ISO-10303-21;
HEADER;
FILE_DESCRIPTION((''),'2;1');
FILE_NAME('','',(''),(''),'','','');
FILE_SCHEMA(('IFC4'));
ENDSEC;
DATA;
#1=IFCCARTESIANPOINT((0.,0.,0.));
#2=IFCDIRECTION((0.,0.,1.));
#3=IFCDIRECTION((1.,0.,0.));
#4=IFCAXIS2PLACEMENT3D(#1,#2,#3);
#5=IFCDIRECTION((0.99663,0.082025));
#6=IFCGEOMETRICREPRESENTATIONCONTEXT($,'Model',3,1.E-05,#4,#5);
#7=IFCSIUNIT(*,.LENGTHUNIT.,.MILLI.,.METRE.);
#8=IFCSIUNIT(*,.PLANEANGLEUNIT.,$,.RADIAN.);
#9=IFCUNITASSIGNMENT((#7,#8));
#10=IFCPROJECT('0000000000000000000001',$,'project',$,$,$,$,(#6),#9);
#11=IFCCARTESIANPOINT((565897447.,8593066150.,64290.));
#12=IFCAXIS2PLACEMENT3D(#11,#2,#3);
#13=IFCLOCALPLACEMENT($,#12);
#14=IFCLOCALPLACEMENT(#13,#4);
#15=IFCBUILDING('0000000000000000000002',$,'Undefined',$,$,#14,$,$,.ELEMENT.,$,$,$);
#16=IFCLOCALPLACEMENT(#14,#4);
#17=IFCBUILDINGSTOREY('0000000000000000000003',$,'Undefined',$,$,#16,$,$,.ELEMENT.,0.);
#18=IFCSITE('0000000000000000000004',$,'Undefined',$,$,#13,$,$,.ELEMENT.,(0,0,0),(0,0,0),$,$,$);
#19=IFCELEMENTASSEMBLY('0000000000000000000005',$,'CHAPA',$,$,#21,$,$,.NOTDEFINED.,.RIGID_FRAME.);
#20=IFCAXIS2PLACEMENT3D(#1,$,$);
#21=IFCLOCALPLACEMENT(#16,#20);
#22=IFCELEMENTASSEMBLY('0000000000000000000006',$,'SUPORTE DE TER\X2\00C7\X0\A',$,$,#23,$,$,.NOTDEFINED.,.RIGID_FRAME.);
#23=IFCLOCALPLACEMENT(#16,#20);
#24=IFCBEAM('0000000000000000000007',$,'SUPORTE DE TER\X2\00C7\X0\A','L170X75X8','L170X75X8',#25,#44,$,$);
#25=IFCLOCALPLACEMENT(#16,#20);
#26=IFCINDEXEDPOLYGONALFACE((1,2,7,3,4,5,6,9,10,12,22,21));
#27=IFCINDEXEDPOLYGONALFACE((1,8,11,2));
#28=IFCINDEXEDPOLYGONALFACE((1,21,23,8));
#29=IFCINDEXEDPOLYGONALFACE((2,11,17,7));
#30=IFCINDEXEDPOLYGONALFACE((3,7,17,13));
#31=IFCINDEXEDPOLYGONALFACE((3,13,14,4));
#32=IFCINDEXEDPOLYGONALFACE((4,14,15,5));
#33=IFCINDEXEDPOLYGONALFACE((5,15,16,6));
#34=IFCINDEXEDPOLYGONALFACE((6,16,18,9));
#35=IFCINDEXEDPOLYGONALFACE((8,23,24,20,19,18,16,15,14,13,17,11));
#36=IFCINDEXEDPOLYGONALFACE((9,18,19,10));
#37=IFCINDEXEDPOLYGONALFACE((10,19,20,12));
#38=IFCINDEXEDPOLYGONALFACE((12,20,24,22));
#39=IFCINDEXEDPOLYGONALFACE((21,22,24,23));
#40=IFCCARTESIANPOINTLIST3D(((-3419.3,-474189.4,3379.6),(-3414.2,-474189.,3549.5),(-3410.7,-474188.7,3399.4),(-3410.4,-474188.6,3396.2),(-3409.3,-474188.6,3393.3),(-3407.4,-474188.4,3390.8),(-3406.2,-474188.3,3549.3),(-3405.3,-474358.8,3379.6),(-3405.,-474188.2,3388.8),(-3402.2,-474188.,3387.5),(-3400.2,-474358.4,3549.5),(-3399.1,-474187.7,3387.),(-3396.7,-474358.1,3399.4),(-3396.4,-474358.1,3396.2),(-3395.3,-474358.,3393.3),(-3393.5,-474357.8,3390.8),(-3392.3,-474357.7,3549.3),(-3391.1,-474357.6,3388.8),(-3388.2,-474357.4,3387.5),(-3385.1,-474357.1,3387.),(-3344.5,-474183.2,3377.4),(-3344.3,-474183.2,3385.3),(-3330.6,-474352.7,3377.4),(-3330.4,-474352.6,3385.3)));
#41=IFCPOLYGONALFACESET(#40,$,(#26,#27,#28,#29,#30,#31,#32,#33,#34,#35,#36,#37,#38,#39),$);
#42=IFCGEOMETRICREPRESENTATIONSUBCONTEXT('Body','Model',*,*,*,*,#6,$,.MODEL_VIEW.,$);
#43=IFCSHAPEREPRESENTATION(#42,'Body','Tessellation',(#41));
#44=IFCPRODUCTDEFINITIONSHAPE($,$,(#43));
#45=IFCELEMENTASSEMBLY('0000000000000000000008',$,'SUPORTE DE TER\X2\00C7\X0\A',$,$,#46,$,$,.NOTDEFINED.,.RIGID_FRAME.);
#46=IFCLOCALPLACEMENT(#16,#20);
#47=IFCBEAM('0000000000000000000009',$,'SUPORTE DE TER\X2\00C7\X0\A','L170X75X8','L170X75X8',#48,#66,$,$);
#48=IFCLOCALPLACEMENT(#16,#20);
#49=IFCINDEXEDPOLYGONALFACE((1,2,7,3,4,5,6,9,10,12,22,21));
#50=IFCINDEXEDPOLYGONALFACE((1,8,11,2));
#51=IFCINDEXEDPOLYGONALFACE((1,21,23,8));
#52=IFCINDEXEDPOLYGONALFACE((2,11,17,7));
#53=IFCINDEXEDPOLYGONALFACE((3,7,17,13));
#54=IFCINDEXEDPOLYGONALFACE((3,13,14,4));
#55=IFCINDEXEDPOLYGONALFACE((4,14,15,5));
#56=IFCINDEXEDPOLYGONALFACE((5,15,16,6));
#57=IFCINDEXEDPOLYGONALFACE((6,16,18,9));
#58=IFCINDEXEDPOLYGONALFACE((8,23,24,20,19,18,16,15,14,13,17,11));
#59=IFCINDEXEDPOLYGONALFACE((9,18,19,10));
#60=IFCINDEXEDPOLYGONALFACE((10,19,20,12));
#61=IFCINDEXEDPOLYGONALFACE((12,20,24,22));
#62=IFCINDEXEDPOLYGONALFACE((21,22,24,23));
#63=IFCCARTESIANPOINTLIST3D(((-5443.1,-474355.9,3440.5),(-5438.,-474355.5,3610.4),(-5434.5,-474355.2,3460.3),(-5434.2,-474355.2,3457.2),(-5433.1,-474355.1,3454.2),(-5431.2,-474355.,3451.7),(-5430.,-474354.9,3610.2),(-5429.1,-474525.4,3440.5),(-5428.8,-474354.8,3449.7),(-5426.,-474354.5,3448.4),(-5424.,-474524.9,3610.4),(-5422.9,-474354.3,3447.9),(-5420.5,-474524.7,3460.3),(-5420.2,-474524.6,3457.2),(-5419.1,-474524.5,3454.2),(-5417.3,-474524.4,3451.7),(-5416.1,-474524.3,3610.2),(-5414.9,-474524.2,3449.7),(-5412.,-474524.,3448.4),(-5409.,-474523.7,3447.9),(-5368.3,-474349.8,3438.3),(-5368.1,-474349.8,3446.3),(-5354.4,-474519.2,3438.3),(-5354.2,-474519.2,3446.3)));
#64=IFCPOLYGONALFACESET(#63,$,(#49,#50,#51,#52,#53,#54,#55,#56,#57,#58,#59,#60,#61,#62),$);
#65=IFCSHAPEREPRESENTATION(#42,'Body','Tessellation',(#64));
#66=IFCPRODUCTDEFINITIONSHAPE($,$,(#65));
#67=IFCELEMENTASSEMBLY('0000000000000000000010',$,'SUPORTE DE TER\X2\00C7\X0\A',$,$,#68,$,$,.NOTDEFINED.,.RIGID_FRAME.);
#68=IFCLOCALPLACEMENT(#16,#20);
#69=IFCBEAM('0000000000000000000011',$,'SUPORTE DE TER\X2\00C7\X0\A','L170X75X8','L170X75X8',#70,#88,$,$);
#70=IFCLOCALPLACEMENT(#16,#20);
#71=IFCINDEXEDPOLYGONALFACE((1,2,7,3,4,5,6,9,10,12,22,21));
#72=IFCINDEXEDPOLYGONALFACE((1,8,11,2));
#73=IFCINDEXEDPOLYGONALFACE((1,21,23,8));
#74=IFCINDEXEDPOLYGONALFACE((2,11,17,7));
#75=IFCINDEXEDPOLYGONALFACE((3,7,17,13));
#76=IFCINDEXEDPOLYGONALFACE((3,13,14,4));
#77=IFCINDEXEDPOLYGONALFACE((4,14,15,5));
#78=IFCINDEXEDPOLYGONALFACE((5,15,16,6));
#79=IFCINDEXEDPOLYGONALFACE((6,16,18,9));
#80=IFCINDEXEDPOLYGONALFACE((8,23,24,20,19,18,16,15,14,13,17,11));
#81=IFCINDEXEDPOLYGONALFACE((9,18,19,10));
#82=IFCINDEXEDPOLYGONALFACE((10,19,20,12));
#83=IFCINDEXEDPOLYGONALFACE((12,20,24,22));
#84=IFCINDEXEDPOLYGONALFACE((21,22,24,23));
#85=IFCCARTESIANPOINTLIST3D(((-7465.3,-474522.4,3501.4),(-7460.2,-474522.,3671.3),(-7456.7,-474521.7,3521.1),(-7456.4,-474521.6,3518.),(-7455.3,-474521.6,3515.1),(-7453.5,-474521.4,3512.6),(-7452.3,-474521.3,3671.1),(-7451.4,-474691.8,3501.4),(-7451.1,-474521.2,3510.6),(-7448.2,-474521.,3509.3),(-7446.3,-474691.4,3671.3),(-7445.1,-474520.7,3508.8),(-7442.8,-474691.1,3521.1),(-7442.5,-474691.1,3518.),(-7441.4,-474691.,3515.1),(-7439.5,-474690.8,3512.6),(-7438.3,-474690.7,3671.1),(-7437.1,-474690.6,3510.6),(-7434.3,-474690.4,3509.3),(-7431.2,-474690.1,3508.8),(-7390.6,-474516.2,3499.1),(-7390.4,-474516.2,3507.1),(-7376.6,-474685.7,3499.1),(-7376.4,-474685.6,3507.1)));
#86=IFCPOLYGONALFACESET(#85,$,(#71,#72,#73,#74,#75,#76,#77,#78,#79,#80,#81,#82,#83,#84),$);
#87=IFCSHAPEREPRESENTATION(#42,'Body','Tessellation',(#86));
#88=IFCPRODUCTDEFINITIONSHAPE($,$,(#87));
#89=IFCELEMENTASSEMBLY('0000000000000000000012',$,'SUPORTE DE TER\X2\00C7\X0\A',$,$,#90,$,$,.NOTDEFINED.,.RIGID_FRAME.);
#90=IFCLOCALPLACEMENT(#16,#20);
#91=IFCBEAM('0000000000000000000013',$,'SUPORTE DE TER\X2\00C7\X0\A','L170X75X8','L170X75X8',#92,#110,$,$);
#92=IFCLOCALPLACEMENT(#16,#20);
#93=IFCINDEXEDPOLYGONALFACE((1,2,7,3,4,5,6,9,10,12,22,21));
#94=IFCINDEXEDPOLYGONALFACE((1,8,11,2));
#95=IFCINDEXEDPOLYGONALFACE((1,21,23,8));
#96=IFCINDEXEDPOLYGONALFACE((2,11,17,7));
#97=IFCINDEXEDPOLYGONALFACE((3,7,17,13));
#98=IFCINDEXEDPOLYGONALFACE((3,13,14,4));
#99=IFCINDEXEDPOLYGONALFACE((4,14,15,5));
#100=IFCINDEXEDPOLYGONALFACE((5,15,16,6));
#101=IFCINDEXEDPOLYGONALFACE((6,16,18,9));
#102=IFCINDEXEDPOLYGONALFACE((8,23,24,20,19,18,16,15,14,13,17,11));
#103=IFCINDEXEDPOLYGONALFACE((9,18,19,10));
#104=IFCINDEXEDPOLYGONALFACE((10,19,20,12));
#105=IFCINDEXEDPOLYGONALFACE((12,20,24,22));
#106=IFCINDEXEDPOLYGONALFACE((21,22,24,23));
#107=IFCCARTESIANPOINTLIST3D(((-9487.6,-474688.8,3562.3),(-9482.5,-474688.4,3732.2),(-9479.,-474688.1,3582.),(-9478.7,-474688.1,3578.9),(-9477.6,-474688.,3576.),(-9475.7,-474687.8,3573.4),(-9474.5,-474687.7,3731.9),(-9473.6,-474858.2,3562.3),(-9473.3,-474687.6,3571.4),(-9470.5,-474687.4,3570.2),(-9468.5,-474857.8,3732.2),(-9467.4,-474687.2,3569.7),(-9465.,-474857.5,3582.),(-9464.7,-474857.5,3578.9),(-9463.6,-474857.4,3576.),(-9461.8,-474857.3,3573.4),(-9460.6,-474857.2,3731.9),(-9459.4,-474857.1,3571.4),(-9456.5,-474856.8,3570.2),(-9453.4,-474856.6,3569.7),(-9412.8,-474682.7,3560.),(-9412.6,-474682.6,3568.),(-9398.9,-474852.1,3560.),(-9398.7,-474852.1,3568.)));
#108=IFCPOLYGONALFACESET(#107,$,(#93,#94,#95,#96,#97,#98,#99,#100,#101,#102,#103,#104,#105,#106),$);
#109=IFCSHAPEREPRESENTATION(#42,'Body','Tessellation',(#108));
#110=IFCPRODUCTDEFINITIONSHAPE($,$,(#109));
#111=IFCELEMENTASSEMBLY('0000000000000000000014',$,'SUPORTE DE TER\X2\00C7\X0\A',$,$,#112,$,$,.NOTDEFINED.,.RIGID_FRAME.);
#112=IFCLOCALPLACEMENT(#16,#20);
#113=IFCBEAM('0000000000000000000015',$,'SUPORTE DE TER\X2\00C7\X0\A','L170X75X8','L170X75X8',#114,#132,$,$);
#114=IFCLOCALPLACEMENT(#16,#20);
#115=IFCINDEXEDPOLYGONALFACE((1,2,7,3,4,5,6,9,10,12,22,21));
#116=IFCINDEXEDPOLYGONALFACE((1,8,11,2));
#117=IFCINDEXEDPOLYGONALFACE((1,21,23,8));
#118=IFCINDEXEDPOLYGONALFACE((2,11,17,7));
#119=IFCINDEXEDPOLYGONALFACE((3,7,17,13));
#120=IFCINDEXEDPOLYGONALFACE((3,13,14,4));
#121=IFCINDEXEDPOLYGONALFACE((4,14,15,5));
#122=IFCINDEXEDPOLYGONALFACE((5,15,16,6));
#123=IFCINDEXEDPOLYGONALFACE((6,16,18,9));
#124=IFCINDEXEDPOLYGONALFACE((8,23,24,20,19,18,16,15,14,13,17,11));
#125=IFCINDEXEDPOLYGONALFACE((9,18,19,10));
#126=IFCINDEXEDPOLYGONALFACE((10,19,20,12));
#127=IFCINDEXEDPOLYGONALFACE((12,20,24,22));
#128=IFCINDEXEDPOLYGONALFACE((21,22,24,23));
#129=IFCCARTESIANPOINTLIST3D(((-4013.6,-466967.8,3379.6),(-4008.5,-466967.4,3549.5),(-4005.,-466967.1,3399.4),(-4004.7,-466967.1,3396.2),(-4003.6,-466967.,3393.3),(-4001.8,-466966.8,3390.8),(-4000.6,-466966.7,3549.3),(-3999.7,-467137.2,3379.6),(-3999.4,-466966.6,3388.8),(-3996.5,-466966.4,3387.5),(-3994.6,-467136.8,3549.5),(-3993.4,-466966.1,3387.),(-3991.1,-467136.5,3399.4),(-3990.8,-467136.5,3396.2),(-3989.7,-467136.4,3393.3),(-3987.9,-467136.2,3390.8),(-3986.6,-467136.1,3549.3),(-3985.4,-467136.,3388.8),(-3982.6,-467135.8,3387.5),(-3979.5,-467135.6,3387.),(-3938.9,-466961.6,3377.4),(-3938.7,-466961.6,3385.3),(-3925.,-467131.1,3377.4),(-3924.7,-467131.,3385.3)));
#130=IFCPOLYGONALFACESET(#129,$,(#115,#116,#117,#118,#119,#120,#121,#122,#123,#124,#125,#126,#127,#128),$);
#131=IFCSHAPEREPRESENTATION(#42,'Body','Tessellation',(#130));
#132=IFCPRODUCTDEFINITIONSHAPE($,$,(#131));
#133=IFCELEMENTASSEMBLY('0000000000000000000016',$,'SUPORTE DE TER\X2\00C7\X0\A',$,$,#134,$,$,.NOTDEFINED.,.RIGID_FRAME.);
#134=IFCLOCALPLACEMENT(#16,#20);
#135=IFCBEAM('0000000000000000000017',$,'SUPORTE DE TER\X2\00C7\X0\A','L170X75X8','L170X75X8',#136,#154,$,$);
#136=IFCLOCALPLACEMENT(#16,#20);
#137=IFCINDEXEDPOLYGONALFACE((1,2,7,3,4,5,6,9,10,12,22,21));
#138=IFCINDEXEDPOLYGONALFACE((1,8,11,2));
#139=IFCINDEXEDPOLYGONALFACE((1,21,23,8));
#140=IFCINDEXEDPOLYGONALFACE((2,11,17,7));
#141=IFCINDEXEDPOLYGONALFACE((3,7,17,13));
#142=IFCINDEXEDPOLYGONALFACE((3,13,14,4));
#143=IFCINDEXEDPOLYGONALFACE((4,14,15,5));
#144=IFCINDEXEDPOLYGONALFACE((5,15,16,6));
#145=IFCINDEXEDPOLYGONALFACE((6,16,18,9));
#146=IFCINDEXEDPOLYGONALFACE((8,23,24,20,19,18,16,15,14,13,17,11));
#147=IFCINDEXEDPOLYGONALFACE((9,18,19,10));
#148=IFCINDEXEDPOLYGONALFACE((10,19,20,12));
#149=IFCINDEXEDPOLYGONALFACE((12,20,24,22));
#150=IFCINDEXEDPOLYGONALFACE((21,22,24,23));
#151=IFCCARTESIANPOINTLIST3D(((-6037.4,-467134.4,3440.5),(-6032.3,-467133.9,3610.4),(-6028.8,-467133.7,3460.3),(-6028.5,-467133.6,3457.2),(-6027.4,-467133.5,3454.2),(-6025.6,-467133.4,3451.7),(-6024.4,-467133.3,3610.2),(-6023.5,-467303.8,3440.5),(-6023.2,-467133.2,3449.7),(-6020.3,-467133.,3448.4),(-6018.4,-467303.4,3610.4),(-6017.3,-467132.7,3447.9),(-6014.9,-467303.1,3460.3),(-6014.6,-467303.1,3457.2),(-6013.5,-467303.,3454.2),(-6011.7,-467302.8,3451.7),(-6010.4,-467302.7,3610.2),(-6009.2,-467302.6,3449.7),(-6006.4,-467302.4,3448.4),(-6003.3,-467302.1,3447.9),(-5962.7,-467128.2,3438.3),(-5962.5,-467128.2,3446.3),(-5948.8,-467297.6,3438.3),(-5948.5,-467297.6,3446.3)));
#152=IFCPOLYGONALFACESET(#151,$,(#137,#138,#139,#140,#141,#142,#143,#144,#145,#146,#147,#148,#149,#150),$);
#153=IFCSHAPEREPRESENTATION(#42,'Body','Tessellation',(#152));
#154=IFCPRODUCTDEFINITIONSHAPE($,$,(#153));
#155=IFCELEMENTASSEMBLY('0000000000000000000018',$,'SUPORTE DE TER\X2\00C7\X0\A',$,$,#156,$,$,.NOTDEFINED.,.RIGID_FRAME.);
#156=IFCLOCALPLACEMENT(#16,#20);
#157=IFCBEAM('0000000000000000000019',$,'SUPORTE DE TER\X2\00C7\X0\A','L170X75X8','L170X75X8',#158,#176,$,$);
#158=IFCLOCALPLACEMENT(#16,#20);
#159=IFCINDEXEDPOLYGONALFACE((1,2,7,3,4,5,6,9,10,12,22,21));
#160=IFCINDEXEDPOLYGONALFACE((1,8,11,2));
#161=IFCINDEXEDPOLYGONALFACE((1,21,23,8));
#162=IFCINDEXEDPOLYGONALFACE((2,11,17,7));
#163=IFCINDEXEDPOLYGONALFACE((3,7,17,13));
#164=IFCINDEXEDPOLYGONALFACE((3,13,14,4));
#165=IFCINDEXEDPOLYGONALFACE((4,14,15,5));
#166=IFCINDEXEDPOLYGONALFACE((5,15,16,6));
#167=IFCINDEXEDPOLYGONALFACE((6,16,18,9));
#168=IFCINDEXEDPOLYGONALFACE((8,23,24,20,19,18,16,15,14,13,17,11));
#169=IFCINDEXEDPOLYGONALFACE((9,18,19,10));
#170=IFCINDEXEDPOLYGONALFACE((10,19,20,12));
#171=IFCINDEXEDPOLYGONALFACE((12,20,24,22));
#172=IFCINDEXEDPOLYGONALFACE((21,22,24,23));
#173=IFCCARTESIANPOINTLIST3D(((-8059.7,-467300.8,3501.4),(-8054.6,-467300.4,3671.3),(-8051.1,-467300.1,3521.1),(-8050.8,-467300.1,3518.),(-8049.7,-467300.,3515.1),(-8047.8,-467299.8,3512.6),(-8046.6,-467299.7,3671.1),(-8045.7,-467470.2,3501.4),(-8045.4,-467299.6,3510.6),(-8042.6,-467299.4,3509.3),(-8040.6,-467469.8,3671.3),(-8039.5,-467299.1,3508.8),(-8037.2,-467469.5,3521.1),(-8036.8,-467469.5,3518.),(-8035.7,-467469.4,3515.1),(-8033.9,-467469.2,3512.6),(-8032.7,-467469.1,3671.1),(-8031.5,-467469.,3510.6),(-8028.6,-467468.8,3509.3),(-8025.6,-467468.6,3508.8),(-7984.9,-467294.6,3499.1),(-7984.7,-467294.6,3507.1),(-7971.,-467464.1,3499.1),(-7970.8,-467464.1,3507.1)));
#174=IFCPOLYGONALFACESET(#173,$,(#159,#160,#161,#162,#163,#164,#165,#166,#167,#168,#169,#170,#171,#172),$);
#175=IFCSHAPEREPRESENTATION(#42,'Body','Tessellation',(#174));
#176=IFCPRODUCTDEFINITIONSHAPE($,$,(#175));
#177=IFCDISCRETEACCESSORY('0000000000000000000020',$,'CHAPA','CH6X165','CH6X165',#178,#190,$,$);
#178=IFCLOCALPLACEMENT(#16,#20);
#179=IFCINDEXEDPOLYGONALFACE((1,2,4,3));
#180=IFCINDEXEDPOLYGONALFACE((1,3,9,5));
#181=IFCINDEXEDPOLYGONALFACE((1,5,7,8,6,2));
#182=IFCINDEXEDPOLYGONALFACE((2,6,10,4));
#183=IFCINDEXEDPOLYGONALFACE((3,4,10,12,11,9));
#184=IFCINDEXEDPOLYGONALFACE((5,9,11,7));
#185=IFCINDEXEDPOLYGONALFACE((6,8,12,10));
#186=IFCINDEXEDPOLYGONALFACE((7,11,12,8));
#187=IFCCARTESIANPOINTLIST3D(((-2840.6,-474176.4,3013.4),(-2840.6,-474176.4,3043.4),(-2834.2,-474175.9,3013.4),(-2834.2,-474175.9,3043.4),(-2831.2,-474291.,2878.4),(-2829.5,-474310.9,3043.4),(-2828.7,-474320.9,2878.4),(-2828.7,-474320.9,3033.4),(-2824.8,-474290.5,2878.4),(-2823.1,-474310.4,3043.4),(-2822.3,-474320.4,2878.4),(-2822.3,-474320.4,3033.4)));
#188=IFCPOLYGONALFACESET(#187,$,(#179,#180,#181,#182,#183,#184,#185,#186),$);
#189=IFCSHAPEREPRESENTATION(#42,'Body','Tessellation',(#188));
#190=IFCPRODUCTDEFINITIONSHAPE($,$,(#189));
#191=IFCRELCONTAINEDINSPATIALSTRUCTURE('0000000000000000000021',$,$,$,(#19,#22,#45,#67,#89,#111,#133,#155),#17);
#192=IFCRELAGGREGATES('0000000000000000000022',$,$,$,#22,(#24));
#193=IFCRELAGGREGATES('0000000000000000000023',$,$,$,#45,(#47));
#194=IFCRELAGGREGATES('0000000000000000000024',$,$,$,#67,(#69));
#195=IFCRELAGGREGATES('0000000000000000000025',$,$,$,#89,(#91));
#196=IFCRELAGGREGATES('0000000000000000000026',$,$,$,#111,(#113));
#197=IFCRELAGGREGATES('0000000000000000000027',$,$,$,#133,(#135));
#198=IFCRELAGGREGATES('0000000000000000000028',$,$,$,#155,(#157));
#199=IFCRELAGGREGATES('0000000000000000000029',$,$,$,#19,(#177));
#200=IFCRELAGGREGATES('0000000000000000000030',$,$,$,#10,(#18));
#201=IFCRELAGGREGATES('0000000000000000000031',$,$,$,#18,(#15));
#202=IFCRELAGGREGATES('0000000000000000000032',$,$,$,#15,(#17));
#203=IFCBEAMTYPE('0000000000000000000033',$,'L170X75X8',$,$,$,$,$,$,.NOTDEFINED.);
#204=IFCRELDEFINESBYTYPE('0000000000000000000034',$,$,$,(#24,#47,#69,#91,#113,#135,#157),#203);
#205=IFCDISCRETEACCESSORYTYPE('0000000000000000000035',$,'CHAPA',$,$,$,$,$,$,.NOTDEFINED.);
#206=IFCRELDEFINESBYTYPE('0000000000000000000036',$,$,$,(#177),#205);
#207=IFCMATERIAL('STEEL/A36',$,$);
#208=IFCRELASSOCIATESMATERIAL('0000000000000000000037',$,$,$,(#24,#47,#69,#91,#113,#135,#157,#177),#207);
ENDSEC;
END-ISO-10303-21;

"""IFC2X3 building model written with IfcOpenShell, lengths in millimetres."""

from ifc_helpers import new_model, si_unit, direction, frame, origin_with_axes, origin_2d_with_axis, place, context, subcontext, project, spatial, polyline, l_section, outline, extrude, material, type_object, element, aggregate, save


model = new_model("IFC2X3")

# Units and contexts
model_context = context("Model", 3, precision=1e-05, world=origin_with_axes(), true_north=direction((0.99663, 0.082025)))
body_context = subcontext(model_context, "Body", "Model", "MODEL_VIEW")
ifc_project = project(units=[si_unit("LENGTHUNIT", "METRE", prefix="MILLI"), si_unit("PLANEANGLEUNIT", "RADIAN")], contexts=[model_context])

# Site, building, storey
site_placement = place(None, frame((565897447.0, 8593066150.0, 64290.0), z_axis=(0.0, 0.0, 1.0), x_axis=(1.0, 0.0, 0.0)))
site = spatial("IfcSite", under=ifc_project, at=site_placement, Name="Undefined", CompositionType="ELEMENT", RefLatitude=(0, 0, 0), RefLongitude=(0, 0, 0))
building_placement = place(site_placement, origin_with_axes())
building = spatial("IfcBuilding", under=site, at=building_placement, Name="Undefined", CompositionType="ELEMENT")
storey_placement = place(building_placement, origin_with_axes())
storey = spatial("IfcBuildingStorey", under=building, at=storey_placement, Name="Undefined", CompositionType="ELEMENT", Elevation=0.0)

# Element assemblies, beams
assembly_1_placement = place(storey_placement, origin_with_axes())
assembly_1 = element("IfcElementAssembly", 1, at=assembly_1_placement, inside=storey, Name="CHAPA", AssemblyPlace="NOTDEFINED", PredefinedType="RIGID_FRAME")
ifc_material_1 = material(Name="STEEL/A36")
assembly_2_placement = place(storey_placement, origin_with_axes())
assembly_2 = element("IfcElementAssembly", 2, at=assembly_2_placement, inside=storey, Name="SUPORTE DE TERÇA", AssemblyPlace="NOTDEFINED", PredefinedType="RIGID_FRAME")
beam_type_1 = type_object("IfcBeamType", Name="L170X75X8", PredefinedType="NOTDEFINED")
beam_1_placement = place(assembly_2_placement, frame((-3365.4, -474355.5, 3463.4), z_axis=(0.029885, 0.00246, 0.99955), x_axis=(-0.082025, 0.99663, 0.0)))
beam_1 = element("IfcBeam", 3, at=beam_1_placement, type_object=beam_type_1, material=ifc_material_1, Name="SUPORTE DE TERÇA", Description="L170X75X8", ObjectType="L170X75X8", context=body_context, shape_type="SweptSolid", body=[
    extrude(l_section(Depth=170.0, Width=75.0, Thickness=8.0, FilletRadius=12.0, at=origin_2d_with_axis()), frame((170.0, 0.0, 0.0), z_axis=(-1.0, 0.0, 0.0), x_axis=(0.0, -1.0, 0.0)), (0.0, 0.0, 1.0), 170.0),
])
aggregate(assembly_2, [beam_1])
assembly_3_placement = place(storey_placement, origin_with_axes())
assembly_3 = element("IfcElementAssembly", 4, at=assembly_3_placement, inside=storey, Name="SUPORTE DE TERÇA", AssemblyPlace="NOTDEFINED", PredefinedType="RIGID_FRAME")
beam_2_placement = place(assembly_3_placement, frame((-5389.2, -474522.1, 3524.4), z_axis=(0.029885, 0.00246, 0.99955), x_axis=(-0.082025, 0.99663, 0.0)))
beam_2 = element("IfcBeam", 5, at=beam_2_placement, type_object=beam_type_1, material=ifc_material_1, Name="SUPORTE DE TERÇA", Description="L170X75X8", ObjectType="L170X75X8", context=body_context, shape_type="SweptSolid", body=[
    extrude(l_section(Depth=170.0, Width=75.0, Thickness=8.0, FilletRadius=12.0, at=origin_2d_with_axis()), frame((170.0, 0.0, 0.0), z_axis=(-1.0, 0.0, 0.0), x_axis=(0.0, -1.0, 0.0)), (0.0, 0.0, 1.0), 170.0),
])
aggregate(assembly_3, [beam_2])
assembly_4_placement = place(storey_placement, origin_with_axes())
assembly_4 = element("IfcElementAssembly", 6, at=assembly_4_placement, inside=storey, Name="SUPORTE DE TERÇA", AssemblyPlace="NOTDEFINED", PredefinedType="RIGID_FRAME")
beam_3_placement = place(assembly_4_placement, frame((-7411.5, -474688.5, 3585.2), z_axis=(0.029885, 0.00246, 0.99955), x_axis=(-0.082025, 0.99663, 0.0)))
beam_3 = element("IfcBeam", 7, at=beam_3_placement, type_object=beam_type_1, material=ifc_material_1, Name="SUPORTE DE TERÇA", Description="L170X75X8", ObjectType="L170X75X8", context=body_context, shape_type="SweptSolid", body=[
    extrude(l_section(Depth=170.0, Width=75.0, Thickness=8.0, FilletRadius=12.0, at=origin_2d_with_axis()), frame((170.0, 0.0, 0.0), z_axis=(-1.0, 0.0, 0.0), x_axis=(0.0, -1.0, 0.0)), (0.0, 0.0, 1.0), 170.0),
])
aggregate(assembly_4, [beam_3])
assembly_5_placement = place(storey_placement, origin_with_axes())
assembly_5 = element("IfcElementAssembly", 8, at=assembly_5_placement, inside=storey, Name="SUPORTE DE TERÇA", AssemblyPlace="NOTDEFINED", PredefinedType="RIGID_FRAME")
beam_4_placement = place(assembly_5_placement, frame((-9433.7, -474855.0, 3646.1), z_axis=(0.029885, 0.00246, 0.99955), x_axis=(-0.082025, 0.99663, 0.0)))
beam_4 = element("IfcBeam", 9, at=beam_4_placement, type_object=beam_type_1, material=ifc_material_1, Name="SUPORTE DE TERÇA", Description="L170X75X8", ObjectType="L170X75X8", context=body_context, shape_type="SweptSolid", body=[
    extrude(l_section(Depth=170.0, Width=75.0, Thickness=8.0, FilletRadius=12.0, at=origin_2d_with_axis()), frame((170.0, 0.0, 0.0), z_axis=(-1.0, 0.0, 0.0), x_axis=(0.0, -1.0, 0.0)), (0.0, 0.0, 1.0), 170.0),
])
aggregate(assembly_5, [beam_4])
assembly_6_placement = place(storey_placement, origin_with_axes())
assembly_6 = element("IfcElementAssembly", 10, at=assembly_6_placement, inside=storey, Name="SUPORTE DE TERÇA", AssemblyPlace="NOTDEFINED", PredefinedType="RIGID_FRAME")
beam_5_placement = place(assembly_6_placement, frame((-3959.8, -467133.9, 3463.4), z_axis=(0.029885, 0.00246, 0.99955), x_axis=(-0.082025, 0.99663, 0.0)))
beam_5 = element("IfcBeam", 11, at=beam_5_placement, type_object=beam_type_1, material=ifc_material_1, Name="SUPORTE DE TERÇA", Description="L170X75X8", ObjectType="L170X75X8", context=body_context, shape_type="SweptSolid", body=[
    extrude(l_section(Depth=170.0, Width=75.0, Thickness=8.0, FilletRadius=12.0, at=origin_2d_with_axis()), frame((170.0, 0.0, 0.0), z_axis=(-1.0, 0.0, 0.0), x_axis=(0.0, -1.0, 0.0)), (0.0, 0.0, 1.0), 170.0),
])
aggregate(assembly_6, [beam_5])
assembly_7_placement = place(storey_placement, origin_with_axes())
assembly_7 = element("IfcElementAssembly", 12, at=assembly_7_placement, inside=storey, Name="SUPORTE DE TERÇA", AssemblyPlace="NOTDEFINED", PredefinedType="RIGID_FRAME")
beam_6_placement = place(assembly_7_placement, frame((-5983.6, -467300.5, 3524.4), z_axis=(0.029885, 0.00246, 0.99955), x_axis=(-0.082025, 0.99663, 0.0)))
beam_6 = element("IfcBeam", 13, at=beam_6_placement, type_object=beam_type_1, material=ifc_material_1, Name="SUPORTE DE TERÇA", Description="L170X75X8", ObjectType="L170X75X8", context=body_context, shape_type="SweptSolid", body=[
    extrude(l_section(Depth=170.0, Width=75.0, Thickness=8.0, FilletRadius=12.0, at=origin_2d_with_axis()), frame((170.0, 0.0, 0.0), z_axis=(-1.0, 0.0, 0.0), x_axis=(0.0, -1.0, 0.0)), (0.0, 0.0, 1.0), 170.0),
])
aggregate(assembly_7, [beam_6])
assembly_8_placement = place(storey_placement, origin_with_axes())
assembly_8 = element("IfcElementAssembly", 14, at=assembly_8_placement, inside=storey, Name="SUPORTE DE TERÇA", AssemblyPlace="NOTDEFINED", PredefinedType="RIGID_FRAME")
beam_7_placement = place(assembly_8_placement, frame((-8005.8, -467466.9, 3585.2), z_axis=(0.029885, 0.00246, 0.99955), x_axis=(-0.082025, 0.99663, 0.0)))
beam_7 = element("IfcBeam", 15, at=beam_7_placement, type_object=beam_type_1, material=ifc_material_1, Name="SUPORTE DE TERÇA", Description="L170X75X8", ObjectType="L170X75X8", context=body_context, shape_type="SweptSolid", body=[
    extrude(l_section(Depth=170.0, Width=75.0, Thickness=8.0, FilletRadius=12.0, at=origin_2d_with_axis()), frame((170.0, 0.0, 0.0), z_axis=(-1.0, 0.0, 0.0), x_axis=(0.0, -1.0, 0.0)), (0.0, 0.0, 1.0), 170.0),
])
aggregate(assembly_8, [beam_7])

# Discrete accessory
discrete_accessory_type_1 = type_object("IfcDiscreteAccessoryType", Name="CHAPA")
discrete_accessory_1_placement = place(assembly_1_placement, frame((-2825.5, -474320.6, 3043.4), z_axis=(0.99663, 0.082025, 0.000004), x_axis=(0.000004, 0.0, -1.0)))
discrete_accessory_1 = element("IfcDiscreteAccessory", 16, at=discrete_accessory_1_placement, type_object=discrete_accessory_type_1, material=ifc_material_1, Name="CHAPA", Description="CH6X165", ObjectType="CH6X165", context=body_context, shape_type="SweptSolid", body=[
    extrude(outline(polyline([(0.0, 10.0), (10.0, 0.0), (165.0, 0.0), (165.0, 30.0), (30.0, 145.0), (0.0, 145.0), (0.0, 10.0)])), frame((0.0, 0.0, -3.2), z_axis=(0.0, 0.0, 1.0), x_axis=(1.0, 0.0, 0.0)), (0.0, 0.0, 1.0), 6.4),
])
aggregate(assembly_1, [discrete_accessory_1])

save(model, "model.ifc")
